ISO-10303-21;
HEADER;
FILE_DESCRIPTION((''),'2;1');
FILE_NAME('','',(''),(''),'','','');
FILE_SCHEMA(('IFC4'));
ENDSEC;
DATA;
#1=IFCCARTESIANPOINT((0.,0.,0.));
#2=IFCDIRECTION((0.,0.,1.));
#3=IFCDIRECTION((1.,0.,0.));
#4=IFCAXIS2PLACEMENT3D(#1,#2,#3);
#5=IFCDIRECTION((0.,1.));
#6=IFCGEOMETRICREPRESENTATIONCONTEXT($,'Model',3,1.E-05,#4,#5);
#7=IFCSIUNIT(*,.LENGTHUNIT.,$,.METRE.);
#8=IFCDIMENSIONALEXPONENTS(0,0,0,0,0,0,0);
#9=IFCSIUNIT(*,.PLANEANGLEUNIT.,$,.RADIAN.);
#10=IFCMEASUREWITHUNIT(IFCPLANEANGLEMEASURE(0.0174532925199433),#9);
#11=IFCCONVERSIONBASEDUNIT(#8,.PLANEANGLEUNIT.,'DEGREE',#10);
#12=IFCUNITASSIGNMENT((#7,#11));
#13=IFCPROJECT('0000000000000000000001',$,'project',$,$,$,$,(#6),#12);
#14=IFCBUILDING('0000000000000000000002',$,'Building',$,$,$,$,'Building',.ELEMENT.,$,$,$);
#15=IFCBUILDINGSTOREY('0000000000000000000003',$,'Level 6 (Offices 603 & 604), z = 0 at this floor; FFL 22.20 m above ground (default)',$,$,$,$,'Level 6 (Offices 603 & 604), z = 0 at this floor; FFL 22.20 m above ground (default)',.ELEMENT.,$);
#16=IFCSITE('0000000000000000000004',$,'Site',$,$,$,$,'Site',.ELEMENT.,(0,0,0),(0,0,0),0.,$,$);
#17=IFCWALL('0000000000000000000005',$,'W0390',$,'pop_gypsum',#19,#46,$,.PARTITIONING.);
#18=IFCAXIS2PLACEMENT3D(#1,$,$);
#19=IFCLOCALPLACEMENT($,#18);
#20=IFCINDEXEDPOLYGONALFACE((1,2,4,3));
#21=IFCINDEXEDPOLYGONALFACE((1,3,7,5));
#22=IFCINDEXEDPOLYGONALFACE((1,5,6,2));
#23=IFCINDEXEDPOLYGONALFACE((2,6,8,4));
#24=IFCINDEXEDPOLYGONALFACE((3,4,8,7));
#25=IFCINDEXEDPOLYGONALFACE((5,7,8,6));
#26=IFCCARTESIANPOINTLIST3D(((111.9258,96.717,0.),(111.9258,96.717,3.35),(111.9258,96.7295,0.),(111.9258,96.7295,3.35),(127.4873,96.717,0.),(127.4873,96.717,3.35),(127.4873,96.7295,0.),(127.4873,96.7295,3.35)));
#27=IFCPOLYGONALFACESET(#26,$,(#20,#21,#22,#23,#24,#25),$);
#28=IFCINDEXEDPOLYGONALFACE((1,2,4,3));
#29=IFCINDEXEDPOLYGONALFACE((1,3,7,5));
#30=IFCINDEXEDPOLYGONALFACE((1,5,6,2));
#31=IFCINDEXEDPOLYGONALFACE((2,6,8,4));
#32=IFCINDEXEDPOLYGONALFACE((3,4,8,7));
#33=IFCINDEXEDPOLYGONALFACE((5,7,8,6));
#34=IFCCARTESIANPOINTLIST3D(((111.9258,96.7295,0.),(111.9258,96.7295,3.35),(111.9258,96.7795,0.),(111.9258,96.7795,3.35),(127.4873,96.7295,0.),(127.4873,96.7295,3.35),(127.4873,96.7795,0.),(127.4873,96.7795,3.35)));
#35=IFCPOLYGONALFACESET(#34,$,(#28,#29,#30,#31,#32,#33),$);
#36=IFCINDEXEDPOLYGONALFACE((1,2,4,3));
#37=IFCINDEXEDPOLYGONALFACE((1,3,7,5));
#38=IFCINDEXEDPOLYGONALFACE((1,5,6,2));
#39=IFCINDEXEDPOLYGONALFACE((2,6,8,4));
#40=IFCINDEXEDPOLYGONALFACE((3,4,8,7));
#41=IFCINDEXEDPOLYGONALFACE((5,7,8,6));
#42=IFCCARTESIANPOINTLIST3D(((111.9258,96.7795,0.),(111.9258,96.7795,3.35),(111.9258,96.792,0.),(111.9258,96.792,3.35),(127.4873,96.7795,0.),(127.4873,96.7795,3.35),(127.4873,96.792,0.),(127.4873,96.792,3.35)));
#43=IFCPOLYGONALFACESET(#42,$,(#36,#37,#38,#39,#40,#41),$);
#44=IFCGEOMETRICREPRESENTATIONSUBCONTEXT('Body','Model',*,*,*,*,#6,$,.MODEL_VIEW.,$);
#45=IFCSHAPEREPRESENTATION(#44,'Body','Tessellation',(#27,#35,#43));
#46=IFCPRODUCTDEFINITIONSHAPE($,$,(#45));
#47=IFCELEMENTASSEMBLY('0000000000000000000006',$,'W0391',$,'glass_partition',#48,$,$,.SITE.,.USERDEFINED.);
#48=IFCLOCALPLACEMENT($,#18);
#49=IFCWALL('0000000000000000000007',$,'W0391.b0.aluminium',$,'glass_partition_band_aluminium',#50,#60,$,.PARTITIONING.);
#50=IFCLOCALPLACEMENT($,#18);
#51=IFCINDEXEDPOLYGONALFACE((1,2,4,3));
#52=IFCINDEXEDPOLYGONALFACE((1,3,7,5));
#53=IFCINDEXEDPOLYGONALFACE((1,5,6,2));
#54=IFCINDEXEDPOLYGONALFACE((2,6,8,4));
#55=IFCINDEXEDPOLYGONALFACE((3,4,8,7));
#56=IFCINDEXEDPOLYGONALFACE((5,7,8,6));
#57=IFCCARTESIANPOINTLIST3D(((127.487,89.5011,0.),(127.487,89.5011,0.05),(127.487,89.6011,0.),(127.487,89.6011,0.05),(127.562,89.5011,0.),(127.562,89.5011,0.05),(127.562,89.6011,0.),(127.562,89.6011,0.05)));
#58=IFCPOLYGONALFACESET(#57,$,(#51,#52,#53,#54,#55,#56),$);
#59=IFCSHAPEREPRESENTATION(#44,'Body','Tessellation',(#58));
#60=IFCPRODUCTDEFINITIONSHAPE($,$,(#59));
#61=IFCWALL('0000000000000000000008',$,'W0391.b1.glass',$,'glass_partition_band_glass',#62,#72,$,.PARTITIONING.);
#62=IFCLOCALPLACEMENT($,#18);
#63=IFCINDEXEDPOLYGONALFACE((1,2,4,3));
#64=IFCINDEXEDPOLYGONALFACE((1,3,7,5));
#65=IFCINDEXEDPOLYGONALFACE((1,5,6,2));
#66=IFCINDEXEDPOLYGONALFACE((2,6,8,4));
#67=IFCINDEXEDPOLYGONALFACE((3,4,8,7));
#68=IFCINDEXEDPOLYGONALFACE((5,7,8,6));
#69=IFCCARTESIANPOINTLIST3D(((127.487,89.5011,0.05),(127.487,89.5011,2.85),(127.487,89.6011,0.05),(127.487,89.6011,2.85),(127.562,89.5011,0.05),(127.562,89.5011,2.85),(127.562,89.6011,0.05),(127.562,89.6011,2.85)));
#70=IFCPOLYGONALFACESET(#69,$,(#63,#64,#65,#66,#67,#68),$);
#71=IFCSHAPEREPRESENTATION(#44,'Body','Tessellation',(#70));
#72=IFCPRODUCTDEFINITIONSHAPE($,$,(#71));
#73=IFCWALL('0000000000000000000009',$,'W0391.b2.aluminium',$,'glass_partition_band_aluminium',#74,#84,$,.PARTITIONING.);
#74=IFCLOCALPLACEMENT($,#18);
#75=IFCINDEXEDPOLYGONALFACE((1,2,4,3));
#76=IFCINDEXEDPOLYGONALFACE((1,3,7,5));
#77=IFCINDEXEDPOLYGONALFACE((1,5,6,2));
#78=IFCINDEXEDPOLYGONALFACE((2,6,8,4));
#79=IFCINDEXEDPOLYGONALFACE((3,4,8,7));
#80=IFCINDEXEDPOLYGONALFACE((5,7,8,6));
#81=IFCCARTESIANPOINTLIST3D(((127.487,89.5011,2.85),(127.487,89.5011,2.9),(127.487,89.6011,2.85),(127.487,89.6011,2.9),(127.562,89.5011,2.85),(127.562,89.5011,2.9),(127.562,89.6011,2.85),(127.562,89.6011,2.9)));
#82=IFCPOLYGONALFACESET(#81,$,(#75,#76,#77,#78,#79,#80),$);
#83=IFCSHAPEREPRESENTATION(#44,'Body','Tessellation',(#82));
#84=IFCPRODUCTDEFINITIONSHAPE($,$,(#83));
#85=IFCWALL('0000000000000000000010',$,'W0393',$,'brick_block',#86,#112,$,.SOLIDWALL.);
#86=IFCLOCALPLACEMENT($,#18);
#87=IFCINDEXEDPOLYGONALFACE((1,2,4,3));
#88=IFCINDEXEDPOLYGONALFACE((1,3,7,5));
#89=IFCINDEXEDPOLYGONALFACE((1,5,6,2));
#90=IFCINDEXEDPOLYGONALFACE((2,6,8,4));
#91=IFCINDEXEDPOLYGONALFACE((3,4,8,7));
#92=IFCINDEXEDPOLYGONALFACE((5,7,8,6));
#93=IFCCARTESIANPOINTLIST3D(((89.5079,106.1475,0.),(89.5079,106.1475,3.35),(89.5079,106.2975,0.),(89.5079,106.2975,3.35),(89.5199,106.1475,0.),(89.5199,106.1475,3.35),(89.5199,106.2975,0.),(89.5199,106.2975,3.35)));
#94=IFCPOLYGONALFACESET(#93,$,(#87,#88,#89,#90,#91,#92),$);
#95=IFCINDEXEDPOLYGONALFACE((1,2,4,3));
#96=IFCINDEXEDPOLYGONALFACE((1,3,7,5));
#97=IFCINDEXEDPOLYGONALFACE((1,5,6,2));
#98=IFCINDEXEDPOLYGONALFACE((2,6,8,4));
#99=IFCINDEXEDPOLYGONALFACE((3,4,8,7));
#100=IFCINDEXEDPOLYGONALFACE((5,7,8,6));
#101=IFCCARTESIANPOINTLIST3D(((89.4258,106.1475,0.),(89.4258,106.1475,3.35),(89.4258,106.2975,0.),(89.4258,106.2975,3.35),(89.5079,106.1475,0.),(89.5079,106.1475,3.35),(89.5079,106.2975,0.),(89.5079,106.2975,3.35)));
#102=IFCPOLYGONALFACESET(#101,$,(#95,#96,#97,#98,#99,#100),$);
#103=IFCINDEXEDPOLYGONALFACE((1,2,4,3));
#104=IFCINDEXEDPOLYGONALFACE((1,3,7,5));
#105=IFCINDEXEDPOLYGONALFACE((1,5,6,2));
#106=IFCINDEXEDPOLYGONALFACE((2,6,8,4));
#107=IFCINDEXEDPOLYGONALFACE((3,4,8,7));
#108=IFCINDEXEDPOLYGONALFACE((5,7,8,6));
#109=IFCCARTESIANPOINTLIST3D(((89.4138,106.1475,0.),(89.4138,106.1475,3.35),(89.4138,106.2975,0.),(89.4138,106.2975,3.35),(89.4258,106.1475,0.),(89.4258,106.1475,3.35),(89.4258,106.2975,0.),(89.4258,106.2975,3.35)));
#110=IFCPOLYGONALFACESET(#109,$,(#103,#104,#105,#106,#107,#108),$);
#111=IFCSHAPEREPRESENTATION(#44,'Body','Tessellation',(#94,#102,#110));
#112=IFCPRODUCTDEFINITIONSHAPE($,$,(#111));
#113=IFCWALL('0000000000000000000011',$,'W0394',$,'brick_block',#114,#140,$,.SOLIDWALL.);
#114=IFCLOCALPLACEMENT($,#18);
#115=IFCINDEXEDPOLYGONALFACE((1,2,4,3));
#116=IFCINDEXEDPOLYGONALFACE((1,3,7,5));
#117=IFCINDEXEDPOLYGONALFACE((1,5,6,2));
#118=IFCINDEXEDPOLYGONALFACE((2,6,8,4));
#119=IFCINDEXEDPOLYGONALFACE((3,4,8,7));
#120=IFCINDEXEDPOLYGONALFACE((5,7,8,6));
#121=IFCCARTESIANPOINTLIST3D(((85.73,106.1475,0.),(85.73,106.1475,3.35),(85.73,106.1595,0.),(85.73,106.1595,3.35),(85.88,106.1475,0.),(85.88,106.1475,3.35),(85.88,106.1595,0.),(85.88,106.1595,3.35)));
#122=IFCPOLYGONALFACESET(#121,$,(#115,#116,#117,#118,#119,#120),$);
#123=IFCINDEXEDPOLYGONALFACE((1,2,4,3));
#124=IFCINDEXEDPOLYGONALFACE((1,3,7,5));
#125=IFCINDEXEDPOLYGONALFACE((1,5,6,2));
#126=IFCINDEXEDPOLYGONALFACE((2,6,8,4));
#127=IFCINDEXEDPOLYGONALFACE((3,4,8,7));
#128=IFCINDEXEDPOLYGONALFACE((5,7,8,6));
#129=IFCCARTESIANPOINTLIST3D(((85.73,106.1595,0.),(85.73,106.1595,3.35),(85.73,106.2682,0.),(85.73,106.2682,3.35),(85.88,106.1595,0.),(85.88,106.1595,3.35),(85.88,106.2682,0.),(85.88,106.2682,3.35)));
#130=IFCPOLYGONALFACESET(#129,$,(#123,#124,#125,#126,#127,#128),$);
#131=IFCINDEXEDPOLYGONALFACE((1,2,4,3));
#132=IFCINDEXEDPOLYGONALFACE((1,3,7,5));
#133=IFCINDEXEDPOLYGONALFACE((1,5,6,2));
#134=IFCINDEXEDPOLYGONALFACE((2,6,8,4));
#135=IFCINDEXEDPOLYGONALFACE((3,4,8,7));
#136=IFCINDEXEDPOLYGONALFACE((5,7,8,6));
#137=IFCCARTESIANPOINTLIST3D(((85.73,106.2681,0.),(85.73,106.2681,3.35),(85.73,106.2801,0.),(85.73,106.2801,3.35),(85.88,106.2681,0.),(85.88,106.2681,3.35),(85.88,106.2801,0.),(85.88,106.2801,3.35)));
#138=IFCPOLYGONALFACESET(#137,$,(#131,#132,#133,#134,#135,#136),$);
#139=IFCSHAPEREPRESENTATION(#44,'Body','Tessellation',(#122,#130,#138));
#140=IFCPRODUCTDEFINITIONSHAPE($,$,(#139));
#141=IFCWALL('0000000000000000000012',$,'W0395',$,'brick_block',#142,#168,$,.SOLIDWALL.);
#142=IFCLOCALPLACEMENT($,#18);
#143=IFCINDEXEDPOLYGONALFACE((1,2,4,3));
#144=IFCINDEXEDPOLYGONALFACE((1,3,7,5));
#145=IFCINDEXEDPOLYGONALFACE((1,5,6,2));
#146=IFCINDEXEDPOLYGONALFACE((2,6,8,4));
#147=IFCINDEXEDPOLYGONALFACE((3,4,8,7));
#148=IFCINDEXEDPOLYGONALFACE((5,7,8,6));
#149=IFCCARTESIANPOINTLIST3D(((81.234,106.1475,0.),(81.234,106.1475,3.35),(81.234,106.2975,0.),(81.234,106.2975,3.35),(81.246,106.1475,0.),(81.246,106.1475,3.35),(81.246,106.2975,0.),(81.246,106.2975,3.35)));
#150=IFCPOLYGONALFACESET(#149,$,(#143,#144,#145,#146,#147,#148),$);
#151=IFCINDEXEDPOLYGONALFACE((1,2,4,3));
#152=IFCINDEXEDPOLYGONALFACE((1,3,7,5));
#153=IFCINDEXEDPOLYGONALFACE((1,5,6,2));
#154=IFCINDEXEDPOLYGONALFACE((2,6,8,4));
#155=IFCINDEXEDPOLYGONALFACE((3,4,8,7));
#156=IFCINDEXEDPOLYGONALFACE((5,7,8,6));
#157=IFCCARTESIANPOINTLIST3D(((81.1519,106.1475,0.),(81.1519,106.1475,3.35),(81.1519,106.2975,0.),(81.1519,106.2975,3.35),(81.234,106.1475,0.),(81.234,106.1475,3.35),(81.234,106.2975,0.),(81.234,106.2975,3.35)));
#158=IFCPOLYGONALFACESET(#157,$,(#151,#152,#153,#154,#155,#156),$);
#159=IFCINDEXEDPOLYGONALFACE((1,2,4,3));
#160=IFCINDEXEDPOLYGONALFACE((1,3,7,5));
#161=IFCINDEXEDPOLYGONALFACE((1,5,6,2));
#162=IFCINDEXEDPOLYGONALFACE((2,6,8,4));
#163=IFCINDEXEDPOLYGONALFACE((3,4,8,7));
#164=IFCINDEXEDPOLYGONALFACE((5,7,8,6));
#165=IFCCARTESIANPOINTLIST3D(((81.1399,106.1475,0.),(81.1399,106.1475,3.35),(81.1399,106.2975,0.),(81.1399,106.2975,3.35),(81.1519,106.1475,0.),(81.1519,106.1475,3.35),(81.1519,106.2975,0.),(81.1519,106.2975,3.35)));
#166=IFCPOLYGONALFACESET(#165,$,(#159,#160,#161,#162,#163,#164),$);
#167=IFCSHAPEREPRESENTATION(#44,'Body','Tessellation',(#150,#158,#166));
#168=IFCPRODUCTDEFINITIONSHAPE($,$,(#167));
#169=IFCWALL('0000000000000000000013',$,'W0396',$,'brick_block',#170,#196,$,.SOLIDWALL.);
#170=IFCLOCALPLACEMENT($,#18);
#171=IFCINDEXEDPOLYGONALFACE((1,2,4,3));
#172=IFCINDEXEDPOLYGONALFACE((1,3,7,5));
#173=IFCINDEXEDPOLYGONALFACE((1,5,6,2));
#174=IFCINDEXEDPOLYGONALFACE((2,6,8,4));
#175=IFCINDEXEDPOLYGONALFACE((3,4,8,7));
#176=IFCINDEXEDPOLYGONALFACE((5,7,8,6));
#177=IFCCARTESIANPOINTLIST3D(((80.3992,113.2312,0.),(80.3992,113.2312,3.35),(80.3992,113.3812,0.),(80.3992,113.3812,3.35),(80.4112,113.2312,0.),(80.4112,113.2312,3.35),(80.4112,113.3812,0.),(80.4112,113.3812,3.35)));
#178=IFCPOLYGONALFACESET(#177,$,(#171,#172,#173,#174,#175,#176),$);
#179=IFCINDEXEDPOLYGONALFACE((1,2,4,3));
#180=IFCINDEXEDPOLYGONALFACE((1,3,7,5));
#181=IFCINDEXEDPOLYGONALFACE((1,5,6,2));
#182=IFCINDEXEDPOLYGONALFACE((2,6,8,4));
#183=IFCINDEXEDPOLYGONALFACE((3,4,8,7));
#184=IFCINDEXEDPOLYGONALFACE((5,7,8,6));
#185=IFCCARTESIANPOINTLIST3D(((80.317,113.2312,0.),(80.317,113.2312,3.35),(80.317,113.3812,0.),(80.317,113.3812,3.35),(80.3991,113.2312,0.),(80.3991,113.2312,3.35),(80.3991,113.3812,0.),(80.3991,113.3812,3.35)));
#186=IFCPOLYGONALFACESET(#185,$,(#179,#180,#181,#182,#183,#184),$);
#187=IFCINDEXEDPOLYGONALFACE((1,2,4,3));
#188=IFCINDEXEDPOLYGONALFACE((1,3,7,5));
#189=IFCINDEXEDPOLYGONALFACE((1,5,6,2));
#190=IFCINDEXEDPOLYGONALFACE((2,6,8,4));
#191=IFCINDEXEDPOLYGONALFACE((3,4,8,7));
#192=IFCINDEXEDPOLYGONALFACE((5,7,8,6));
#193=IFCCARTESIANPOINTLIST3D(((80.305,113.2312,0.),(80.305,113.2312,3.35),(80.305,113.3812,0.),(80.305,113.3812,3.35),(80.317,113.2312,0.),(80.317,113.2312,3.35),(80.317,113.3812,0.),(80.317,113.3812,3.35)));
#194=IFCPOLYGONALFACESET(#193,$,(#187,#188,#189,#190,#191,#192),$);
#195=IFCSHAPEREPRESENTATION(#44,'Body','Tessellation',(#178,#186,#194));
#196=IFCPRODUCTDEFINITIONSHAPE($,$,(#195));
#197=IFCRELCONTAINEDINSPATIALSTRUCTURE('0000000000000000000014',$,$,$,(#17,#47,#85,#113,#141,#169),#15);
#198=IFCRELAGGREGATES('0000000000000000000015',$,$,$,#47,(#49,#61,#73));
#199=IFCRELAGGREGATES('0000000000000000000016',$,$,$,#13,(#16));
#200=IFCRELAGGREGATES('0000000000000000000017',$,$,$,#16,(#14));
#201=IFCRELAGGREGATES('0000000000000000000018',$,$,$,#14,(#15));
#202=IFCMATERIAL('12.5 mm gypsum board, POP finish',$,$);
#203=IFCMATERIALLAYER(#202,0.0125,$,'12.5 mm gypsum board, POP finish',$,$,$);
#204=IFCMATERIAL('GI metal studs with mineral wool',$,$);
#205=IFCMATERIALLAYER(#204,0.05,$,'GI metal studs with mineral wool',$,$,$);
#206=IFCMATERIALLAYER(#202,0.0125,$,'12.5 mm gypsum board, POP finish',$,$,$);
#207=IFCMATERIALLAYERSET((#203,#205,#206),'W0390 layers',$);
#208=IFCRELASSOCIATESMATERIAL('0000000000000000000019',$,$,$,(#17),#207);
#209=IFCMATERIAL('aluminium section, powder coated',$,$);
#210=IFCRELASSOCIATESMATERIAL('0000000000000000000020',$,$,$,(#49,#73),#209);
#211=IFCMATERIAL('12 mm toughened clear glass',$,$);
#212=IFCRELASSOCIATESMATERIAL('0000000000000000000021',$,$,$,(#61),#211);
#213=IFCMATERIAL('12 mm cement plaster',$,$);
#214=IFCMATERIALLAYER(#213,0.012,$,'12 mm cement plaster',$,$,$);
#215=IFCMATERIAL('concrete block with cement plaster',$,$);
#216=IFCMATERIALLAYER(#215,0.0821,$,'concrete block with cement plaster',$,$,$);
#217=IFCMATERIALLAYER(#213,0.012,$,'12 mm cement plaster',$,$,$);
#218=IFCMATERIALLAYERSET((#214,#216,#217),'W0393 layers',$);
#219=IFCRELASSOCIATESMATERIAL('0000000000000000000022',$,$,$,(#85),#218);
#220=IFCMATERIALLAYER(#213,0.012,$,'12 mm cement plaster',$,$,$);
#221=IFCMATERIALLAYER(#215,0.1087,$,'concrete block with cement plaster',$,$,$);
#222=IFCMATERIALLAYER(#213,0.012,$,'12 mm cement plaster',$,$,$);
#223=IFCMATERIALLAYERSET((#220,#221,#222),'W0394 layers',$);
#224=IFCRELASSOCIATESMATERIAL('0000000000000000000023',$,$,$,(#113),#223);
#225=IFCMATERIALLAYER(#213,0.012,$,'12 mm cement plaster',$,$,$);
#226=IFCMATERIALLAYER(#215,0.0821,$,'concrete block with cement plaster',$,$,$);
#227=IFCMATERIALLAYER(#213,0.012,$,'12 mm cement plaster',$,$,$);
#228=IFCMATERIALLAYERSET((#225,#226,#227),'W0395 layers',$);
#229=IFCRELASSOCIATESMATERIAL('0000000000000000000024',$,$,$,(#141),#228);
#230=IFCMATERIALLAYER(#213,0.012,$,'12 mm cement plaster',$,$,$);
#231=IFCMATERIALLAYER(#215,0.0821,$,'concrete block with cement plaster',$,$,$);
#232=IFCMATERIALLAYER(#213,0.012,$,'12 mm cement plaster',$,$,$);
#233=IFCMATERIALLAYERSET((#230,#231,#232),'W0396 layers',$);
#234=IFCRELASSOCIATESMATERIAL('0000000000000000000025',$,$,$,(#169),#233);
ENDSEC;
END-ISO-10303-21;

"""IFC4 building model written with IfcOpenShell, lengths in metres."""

from ifc_helpers import new_model, entity, si_unit, converted_unit, direction, frame, frame_2d, origin_with_axes, place, context, subcontext, project, spatial, rectangle, extrude, material, layer, layer_set, layer_usage, element, aggregate, save


model = new_model("IFC4")

# Units and contexts
model_context = context("Model", 3, precision=1e-05, world=origin_with_axes(), true_north=direction((0.0, 1.0)))
body_context = subcontext(model_context, "Body", "Model", "MODEL_VIEW")
ifc_project = project(units=[si_unit("LENGTHUNIT", "METRE"), converted_unit("PLANEANGLEUNIT", "DEGREE", entity("IfcPlaneAngleMeasure", 0.0174532925199433), si_unit("PLANEANGLEUNIT", "RADIAN"), dimensions=[0, 0, 0, 0, 0, 0, 0])], contexts=[model_context])

# Site, building, storey
site = spatial("IfcSite", under=ifc_project, Name="Site", LongName="Site", CompositionType="ELEMENT", RefLatitude=(0, 0, 0), RefLongitude=(0, 0, 0), RefElevation=0.0)
building = spatial("IfcBuilding", under=site, Name="Building", LongName="Building", CompositionType="ELEMENT")
storey = spatial("IfcBuildingStorey", under=building, Name="Level 6 (Offices 603 & 604), z = 0 at this floor; FFL 22.20 m above ground (default)", LongName="Level 6 (Offices 603 & 604), z = 0 at this floor; FFL 22.20 m above ground (default)", CompositionType="ELEMENT")

# Shared definitions
ifc_material_1 = material(Name="aluminium section, powder coated")
placement = place(None, origin_with_axes())

# Wall
ifc_material_2 = material(Name="12.5 mm gypsum board, POP finish")
ifc_material_3 = material(Name="GI metal studs with mineral wool")
ifc_layer_1 = layer(ifc_material_2, 0.0125, Name="12.5 mm gypsum board, POP finish")
ifc_layer_2 = layer(ifc_material_3, 0.05, Name="GI metal studs with mineral wool")
ifc_layer_3 = layer(ifc_material_2, 0.0125, Name="12.5 mm gypsum board, POP finish")
ifc_layer_set_1 = layer_set([ifc_layer_1, ifc_layer_2, ifc_layer_3], Name="W0390 layers")
ifc_layer_usage_1 = layer_usage(ifc_layer_set_1, "AXIS2", "POSITIVE", -0.0375)
element("IfcWall", 1, at=placement, inside=storey, material=ifc_layer_usage_1, Name="W0390", ObjectType="pop_gypsum", PredefinedType="PARTITIONING", context=body_context, shape_type="SweptSolid", body=[
    extrude(rectangle(XDim=15.5615, YDim=0.0125, at=frame_2d((0.0, 0.0), x_axis=(1.0, 0.0))), frame((119.7065, 96.7232, 0.0), z_axis=(0.0, 0.0, 1.0), x_axis=(1.0, 0.0, 0.0)), (0.0, 0.0, 1.0), 3.35),
    extrude(rectangle(XDim=15.5615, YDim=0.05, at=frame_2d((0.0, 0.0312), x_axis=(1.0, 0.0))), frame((119.7065, 96.7232, 0.0), z_axis=(0.0, 0.0, 1.0), x_axis=(1.0, 0.0, 0.0)), (0.0, 0.0, 1.0), 3.35),
    extrude(rectangle(XDim=15.5615, YDim=0.0125, at=frame_2d((0.0, 0.0625), x_axis=(1.0, 0.0))), frame((119.7065, 96.7232, 0.0), z_axis=(0.0, 0.0, 1.0), x_axis=(1.0, 0.0, 0.0)), (0.0, 0.0, 1.0), 3.35),
])

# Element assembly, walls
assembly_1 = element("IfcElementAssembly", 2, inside=storey, Name="W0391", ObjectType="glass_partition", AssemblyPlace="SITE", PredefinedType="USERDEFINED")
wall_1 = element("IfcWall", 3, at=placement, material=ifc_material_1, Name="W0391.b0.aluminium", ObjectType="glass_partition_band_aluminium", PredefinedType="PARTITIONING", context=body_context, shape_type="SweptSolid", body=[
    extrude(rectangle(XDim=0.1, YDim=0.075, at=frame_2d((0.0, 0.0), x_axis=(0.0, 1.0))), frame((127.5245, 89.5511, 0.0), z_axis=(0.0, 0.0, 1.0), x_axis=(1.0, 0.0, 0.0)), (0.0, 0.0, 1.0), 0.05),
])
ifc_material_4 = material(Name="12 mm toughened clear glass")
wall_2 = element("IfcWall", 4, at=placement, material=ifc_material_4, Name="W0391.b1.glass", ObjectType="glass_partition_band_glass", PredefinedType="PARTITIONING", context=body_context, shape_type="SweptSolid", body=[
    extrude(rectangle(XDim=0.1, YDim=0.075, at=frame_2d((0.0, 0.0), x_axis=(0.0, 1.0))), frame((127.5245, 89.5511, 0.05), z_axis=(0.0, 0.0, 1.0), x_axis=(1.0, 0.0, 0.0)), (0.0, 0.0, 1.0), 2.8),
])
wall_3 = element("IfcWall", 5, at=placement, material=ifc_material_1, Name="W0391.b2.aluminium", ObjectType="glass_partition_band_aluminium", PredefinedType="PARTITIONING", context=body_context, shape_type="SweptSolid", body=[
    extrude(rectangle(XDim=0.1, YDim=0.075, at=frame_2d((0.0, 0.0), x_axis=(0.0, 1.0))), frame((127.5245, 89.5511, 2.85), z_axis=(0.0, 0.0, 1.0), x_axis=(1.0, 0.0, 0.0)), (0.0, 0.0, 1.0), 0.05),
])
aggregate(assembly_1, [wall_1, wall_2, wall_3])

# Walls
ifc_material_5 = material(Name="12 mm cement plaster")
ifc_layer_4 = layer(ifc_material_5, 0.012, Name="12 mm cement plaster")
ifc_material_6 = material(Name="concrete block with cement plaster")
ifc_layer_5 = layer(ifc_material_6, 0.0821, Name="concrete block with cement plaster")
ifc_layer_6 = layer(ifc_material_5, 0.012, Name="12 mm cement plaster")
ifc_layer_set_2 = layer_set([ifc_layer_4, ifc_layer_5, ifc_layer_6], Name="W0393 layers")
ifc_layer_usage_2 = layer_usage(ifc_layer_set_2, "AXIS2", "POSITIVE", -0.053)
element("IfcWall", 6, at=placement, inside=storey, material=ifc_layer_usage_2, Name="W0393", ObjectType="brick_block", PredefinedType="SOLIDWALL", context=body_context, shape_type="SweptSolid", body=[
    extrude(rectangle(XDim=0.15, YDim=0.012, at=frame_2d((0.0, 0.0), x_axis=(0.0, 1.0))), frame((89.5139, 106.2225, 0.0), z_axis=(0.0, 0.0, 1.0), x_axis=(1.0, 0.0, 0.0)), (0.0, 0.0, 1.0), 3.35),
    extrude(rectangle(XDim=0.15, YDim=0.0821, at=frame_2d((-0.0471, 0.0), x_axis=(0.0, 1.0))), frame((89.5139, 106.2225, 0.0), z_axis=(0.0, 0.0, 1.0), x_axis=(1.0, 0.0, 0.0)), (0.0, 0.0, 1.0), 3.35),
    extrude(rectangle(XDim=0.15, YDim=0.012, at=frame_2d((-0.0941, 0.0), x_axis=(0.0, 1.0))), frame((89.5139, 106.2225, 0.0), z_axis=(0.0, 0.0, 1.0), x_axis=(1.0, 0.0, 0.0)), (0.0, 0.0, 1.0), 3.35),
])
ifc_layer_7 = layer(ifc_material_5, 0.012, Name="12 mm cement plaster")
ifc_layer_8 = layer(ifc_material_6, 0.1087, Name="concrete block with cement plaster")
ifc_layer_9 = layer(ifc_material_5, 0.012, Name="12 mm cement plaster")
ifc_layer_set_3 = layer_set([ifc_layer_7, ifc_layer_8, ifc_layer_9], Name="W0394 layers")
ifc_layer_usage_3 = layer_usage(ifc_layer_set_3, "AXIS2", "POSITIVE", -0.0664)
element("IfcWall", 7, at=placement, inside=storey, material=ifc_layer_usage_3, Name="W0394", ObjectType="brick_block", PredefinedType="SOLIDWALL", context=body_context, shape_type="SweptSolid", body=[
    extrude(rectangle(XDim=0.15, YDim=0.012, at=frame_2d((0.0, 0.0), x_axis=(1.0, 0.0))), frame((85.805, 106.1535, 0.0), z_axis=(0.0, 0.0, 1.0), x_axis=(1.0, 0.0, 0.0)), (0.0, 0.0, 1.0), 3.35),
    extrude(rectangle(XDim=0.15, YDim=0.1087, at=frame_2d((0.0, 0.0604), x_axis=(1.0, 0.0))), frame((85.805, 106.1535, 0.0), z_axis=(0.0, 0.0, 1.0), x_axis=(1.0, 0.0, 0.0)), (0.0, 0.0, 1.0), 3.35),
    extrude(rectangle(XDim=0.15, YDim=0.012, at=frame_2d((0.0, 0.1207), x_axis=(1.0, 0.0))), frame((85.805, 106.1535, 0.0), z_axis=(0.0, 0.0, 1.0), x_axis=(1.0, 0.0, 0.0)), (0.0, 0.0, 1.0), 3.35),
])
ifc_layer_10 = layer(ifc_material_5, 0.012, Name="12 mm cement plaster")
ifc_layer_11 = layer(ifc_material_6, 0.0821, Name="concrete block with cement plaster")
ifc_layer_12 = layer(ifc_material_5, 0.012, Name="12 mm cement plaster")
ifc_layer_set_4 = layer_set([ifc_layer_10, ifc_layer_11, ifc_layer_12], Name="W0395 layers")
ifc_layer_usage_4 = layer_usage(ifc_layer_set_4, "AXIS2", "POSITIVE", -0.053)
element("IfcWall", 8, at=placement, inside=storey, material=ifc_layer_usage_4, Name="W0395", ObjectType="brick_block", PredefinedType="SOLIDWALL", context=body_context, shape_type="SweptSolid", body=[
    extrude(rectangle(XDim=0.15, YDim=0.012, at=frame_2d((0.0, 0.0), x_axis=(0.0, 1.0))), frame((81.24, 106.2225, 0.0), z_axis=(0.0, 0.0, 1.0), x_axis=(1.0, 0.0, 0.0)), (0.0, 0.0, 1.0), 3.35),
    extrude(rectangle(XDim=0.15, YDim=0.0821, at=frame_2d((-0.0471, 0.0), x_axis=(0.0, 1.0))), frame((81.24, 106.2225, 0.0), z_axis=(0.0, 0.0, 1.0), x_axis=(1.0, 0.0, 0.0)), (0.0, 0.0, 1.0), 3.35),
    extrude(rectangle(XDim=0.15, YDim=0.012, at=frame_2d((-0.0941, 0.0), x_axis=(0.0, 1.0))), frame((81.24, 106.2225, 0.0), z_axis=(0.0, 0.0, 1.0), x_axis=(1.0, 0.0, 0.0)), (0.0, 0.0, 1.0), 3.35),
])
ifc_layer_13 = layer(ifc_material_5, 0.012, Name="12 mm cement plaster")
ifc_layer_14 = layer(ifc_material_6, 0.0821, Name="concrete block with cement plaster")
ifc_layer_15 = layer(ifc_material_5, 0.012, Name="12 mm cement plaster")
ifc_layer_set_5 = layer_set([ifc_layer_13, ifc_layer_14, ifc_layer_15], Name="W0396 layers")
ifc_layer_usage_5 = layer_usage(ifc_layer_set_5, "AXIS2", "POSITIVE", -0.053)
element("IfcWall", 9, at=placement, inside=storey, material=ifc_layer_usage_5, Name="W0396", ObjectType="brick_block", PredefinedType="SOLIDWALL", context=body_context, shape_type="SweptSolid", body=[
    extrude(rectangle(XDim=0.15, YDim=0.012, at=frame_2d((0.0, 0.0), x_axis=(0.0, 1.0))), frame((80.4052, 113.3062, 0.0), z_axis=(0.0, 0.0, 1.0), x_axis=(1.0, 0.0, 0.0)), (0.0, 0.0, 1.0), 3.35),
    extrude(rectangle(XDim=0.15, YDim=0.0821, at=frame_2d((-0.0471, 0.0), x_axis=(0.0, 1.0))), frame((80.4052, 113.3062, 0.0), z_axis=(0.0, 0.0, 1.0), x_axis=(1.0, 0.0, 0.0)), (0.0, 0.0, 1.0), 3.35),
    extrude(rectangle(XDim=0.15, YDim=0.012, at=frame_2d((-0.0941, 0.0), x_axis=(0.0, 1.0))), frame((80.4052, 113.3062, 0.0), z_axis=(0.0, 0.0, 1.0), x_axis=(1.0, 0.0, 0.0)), (0.0, 0.0, 1.0), 3.35),
])

save(model, "model.ifc")
